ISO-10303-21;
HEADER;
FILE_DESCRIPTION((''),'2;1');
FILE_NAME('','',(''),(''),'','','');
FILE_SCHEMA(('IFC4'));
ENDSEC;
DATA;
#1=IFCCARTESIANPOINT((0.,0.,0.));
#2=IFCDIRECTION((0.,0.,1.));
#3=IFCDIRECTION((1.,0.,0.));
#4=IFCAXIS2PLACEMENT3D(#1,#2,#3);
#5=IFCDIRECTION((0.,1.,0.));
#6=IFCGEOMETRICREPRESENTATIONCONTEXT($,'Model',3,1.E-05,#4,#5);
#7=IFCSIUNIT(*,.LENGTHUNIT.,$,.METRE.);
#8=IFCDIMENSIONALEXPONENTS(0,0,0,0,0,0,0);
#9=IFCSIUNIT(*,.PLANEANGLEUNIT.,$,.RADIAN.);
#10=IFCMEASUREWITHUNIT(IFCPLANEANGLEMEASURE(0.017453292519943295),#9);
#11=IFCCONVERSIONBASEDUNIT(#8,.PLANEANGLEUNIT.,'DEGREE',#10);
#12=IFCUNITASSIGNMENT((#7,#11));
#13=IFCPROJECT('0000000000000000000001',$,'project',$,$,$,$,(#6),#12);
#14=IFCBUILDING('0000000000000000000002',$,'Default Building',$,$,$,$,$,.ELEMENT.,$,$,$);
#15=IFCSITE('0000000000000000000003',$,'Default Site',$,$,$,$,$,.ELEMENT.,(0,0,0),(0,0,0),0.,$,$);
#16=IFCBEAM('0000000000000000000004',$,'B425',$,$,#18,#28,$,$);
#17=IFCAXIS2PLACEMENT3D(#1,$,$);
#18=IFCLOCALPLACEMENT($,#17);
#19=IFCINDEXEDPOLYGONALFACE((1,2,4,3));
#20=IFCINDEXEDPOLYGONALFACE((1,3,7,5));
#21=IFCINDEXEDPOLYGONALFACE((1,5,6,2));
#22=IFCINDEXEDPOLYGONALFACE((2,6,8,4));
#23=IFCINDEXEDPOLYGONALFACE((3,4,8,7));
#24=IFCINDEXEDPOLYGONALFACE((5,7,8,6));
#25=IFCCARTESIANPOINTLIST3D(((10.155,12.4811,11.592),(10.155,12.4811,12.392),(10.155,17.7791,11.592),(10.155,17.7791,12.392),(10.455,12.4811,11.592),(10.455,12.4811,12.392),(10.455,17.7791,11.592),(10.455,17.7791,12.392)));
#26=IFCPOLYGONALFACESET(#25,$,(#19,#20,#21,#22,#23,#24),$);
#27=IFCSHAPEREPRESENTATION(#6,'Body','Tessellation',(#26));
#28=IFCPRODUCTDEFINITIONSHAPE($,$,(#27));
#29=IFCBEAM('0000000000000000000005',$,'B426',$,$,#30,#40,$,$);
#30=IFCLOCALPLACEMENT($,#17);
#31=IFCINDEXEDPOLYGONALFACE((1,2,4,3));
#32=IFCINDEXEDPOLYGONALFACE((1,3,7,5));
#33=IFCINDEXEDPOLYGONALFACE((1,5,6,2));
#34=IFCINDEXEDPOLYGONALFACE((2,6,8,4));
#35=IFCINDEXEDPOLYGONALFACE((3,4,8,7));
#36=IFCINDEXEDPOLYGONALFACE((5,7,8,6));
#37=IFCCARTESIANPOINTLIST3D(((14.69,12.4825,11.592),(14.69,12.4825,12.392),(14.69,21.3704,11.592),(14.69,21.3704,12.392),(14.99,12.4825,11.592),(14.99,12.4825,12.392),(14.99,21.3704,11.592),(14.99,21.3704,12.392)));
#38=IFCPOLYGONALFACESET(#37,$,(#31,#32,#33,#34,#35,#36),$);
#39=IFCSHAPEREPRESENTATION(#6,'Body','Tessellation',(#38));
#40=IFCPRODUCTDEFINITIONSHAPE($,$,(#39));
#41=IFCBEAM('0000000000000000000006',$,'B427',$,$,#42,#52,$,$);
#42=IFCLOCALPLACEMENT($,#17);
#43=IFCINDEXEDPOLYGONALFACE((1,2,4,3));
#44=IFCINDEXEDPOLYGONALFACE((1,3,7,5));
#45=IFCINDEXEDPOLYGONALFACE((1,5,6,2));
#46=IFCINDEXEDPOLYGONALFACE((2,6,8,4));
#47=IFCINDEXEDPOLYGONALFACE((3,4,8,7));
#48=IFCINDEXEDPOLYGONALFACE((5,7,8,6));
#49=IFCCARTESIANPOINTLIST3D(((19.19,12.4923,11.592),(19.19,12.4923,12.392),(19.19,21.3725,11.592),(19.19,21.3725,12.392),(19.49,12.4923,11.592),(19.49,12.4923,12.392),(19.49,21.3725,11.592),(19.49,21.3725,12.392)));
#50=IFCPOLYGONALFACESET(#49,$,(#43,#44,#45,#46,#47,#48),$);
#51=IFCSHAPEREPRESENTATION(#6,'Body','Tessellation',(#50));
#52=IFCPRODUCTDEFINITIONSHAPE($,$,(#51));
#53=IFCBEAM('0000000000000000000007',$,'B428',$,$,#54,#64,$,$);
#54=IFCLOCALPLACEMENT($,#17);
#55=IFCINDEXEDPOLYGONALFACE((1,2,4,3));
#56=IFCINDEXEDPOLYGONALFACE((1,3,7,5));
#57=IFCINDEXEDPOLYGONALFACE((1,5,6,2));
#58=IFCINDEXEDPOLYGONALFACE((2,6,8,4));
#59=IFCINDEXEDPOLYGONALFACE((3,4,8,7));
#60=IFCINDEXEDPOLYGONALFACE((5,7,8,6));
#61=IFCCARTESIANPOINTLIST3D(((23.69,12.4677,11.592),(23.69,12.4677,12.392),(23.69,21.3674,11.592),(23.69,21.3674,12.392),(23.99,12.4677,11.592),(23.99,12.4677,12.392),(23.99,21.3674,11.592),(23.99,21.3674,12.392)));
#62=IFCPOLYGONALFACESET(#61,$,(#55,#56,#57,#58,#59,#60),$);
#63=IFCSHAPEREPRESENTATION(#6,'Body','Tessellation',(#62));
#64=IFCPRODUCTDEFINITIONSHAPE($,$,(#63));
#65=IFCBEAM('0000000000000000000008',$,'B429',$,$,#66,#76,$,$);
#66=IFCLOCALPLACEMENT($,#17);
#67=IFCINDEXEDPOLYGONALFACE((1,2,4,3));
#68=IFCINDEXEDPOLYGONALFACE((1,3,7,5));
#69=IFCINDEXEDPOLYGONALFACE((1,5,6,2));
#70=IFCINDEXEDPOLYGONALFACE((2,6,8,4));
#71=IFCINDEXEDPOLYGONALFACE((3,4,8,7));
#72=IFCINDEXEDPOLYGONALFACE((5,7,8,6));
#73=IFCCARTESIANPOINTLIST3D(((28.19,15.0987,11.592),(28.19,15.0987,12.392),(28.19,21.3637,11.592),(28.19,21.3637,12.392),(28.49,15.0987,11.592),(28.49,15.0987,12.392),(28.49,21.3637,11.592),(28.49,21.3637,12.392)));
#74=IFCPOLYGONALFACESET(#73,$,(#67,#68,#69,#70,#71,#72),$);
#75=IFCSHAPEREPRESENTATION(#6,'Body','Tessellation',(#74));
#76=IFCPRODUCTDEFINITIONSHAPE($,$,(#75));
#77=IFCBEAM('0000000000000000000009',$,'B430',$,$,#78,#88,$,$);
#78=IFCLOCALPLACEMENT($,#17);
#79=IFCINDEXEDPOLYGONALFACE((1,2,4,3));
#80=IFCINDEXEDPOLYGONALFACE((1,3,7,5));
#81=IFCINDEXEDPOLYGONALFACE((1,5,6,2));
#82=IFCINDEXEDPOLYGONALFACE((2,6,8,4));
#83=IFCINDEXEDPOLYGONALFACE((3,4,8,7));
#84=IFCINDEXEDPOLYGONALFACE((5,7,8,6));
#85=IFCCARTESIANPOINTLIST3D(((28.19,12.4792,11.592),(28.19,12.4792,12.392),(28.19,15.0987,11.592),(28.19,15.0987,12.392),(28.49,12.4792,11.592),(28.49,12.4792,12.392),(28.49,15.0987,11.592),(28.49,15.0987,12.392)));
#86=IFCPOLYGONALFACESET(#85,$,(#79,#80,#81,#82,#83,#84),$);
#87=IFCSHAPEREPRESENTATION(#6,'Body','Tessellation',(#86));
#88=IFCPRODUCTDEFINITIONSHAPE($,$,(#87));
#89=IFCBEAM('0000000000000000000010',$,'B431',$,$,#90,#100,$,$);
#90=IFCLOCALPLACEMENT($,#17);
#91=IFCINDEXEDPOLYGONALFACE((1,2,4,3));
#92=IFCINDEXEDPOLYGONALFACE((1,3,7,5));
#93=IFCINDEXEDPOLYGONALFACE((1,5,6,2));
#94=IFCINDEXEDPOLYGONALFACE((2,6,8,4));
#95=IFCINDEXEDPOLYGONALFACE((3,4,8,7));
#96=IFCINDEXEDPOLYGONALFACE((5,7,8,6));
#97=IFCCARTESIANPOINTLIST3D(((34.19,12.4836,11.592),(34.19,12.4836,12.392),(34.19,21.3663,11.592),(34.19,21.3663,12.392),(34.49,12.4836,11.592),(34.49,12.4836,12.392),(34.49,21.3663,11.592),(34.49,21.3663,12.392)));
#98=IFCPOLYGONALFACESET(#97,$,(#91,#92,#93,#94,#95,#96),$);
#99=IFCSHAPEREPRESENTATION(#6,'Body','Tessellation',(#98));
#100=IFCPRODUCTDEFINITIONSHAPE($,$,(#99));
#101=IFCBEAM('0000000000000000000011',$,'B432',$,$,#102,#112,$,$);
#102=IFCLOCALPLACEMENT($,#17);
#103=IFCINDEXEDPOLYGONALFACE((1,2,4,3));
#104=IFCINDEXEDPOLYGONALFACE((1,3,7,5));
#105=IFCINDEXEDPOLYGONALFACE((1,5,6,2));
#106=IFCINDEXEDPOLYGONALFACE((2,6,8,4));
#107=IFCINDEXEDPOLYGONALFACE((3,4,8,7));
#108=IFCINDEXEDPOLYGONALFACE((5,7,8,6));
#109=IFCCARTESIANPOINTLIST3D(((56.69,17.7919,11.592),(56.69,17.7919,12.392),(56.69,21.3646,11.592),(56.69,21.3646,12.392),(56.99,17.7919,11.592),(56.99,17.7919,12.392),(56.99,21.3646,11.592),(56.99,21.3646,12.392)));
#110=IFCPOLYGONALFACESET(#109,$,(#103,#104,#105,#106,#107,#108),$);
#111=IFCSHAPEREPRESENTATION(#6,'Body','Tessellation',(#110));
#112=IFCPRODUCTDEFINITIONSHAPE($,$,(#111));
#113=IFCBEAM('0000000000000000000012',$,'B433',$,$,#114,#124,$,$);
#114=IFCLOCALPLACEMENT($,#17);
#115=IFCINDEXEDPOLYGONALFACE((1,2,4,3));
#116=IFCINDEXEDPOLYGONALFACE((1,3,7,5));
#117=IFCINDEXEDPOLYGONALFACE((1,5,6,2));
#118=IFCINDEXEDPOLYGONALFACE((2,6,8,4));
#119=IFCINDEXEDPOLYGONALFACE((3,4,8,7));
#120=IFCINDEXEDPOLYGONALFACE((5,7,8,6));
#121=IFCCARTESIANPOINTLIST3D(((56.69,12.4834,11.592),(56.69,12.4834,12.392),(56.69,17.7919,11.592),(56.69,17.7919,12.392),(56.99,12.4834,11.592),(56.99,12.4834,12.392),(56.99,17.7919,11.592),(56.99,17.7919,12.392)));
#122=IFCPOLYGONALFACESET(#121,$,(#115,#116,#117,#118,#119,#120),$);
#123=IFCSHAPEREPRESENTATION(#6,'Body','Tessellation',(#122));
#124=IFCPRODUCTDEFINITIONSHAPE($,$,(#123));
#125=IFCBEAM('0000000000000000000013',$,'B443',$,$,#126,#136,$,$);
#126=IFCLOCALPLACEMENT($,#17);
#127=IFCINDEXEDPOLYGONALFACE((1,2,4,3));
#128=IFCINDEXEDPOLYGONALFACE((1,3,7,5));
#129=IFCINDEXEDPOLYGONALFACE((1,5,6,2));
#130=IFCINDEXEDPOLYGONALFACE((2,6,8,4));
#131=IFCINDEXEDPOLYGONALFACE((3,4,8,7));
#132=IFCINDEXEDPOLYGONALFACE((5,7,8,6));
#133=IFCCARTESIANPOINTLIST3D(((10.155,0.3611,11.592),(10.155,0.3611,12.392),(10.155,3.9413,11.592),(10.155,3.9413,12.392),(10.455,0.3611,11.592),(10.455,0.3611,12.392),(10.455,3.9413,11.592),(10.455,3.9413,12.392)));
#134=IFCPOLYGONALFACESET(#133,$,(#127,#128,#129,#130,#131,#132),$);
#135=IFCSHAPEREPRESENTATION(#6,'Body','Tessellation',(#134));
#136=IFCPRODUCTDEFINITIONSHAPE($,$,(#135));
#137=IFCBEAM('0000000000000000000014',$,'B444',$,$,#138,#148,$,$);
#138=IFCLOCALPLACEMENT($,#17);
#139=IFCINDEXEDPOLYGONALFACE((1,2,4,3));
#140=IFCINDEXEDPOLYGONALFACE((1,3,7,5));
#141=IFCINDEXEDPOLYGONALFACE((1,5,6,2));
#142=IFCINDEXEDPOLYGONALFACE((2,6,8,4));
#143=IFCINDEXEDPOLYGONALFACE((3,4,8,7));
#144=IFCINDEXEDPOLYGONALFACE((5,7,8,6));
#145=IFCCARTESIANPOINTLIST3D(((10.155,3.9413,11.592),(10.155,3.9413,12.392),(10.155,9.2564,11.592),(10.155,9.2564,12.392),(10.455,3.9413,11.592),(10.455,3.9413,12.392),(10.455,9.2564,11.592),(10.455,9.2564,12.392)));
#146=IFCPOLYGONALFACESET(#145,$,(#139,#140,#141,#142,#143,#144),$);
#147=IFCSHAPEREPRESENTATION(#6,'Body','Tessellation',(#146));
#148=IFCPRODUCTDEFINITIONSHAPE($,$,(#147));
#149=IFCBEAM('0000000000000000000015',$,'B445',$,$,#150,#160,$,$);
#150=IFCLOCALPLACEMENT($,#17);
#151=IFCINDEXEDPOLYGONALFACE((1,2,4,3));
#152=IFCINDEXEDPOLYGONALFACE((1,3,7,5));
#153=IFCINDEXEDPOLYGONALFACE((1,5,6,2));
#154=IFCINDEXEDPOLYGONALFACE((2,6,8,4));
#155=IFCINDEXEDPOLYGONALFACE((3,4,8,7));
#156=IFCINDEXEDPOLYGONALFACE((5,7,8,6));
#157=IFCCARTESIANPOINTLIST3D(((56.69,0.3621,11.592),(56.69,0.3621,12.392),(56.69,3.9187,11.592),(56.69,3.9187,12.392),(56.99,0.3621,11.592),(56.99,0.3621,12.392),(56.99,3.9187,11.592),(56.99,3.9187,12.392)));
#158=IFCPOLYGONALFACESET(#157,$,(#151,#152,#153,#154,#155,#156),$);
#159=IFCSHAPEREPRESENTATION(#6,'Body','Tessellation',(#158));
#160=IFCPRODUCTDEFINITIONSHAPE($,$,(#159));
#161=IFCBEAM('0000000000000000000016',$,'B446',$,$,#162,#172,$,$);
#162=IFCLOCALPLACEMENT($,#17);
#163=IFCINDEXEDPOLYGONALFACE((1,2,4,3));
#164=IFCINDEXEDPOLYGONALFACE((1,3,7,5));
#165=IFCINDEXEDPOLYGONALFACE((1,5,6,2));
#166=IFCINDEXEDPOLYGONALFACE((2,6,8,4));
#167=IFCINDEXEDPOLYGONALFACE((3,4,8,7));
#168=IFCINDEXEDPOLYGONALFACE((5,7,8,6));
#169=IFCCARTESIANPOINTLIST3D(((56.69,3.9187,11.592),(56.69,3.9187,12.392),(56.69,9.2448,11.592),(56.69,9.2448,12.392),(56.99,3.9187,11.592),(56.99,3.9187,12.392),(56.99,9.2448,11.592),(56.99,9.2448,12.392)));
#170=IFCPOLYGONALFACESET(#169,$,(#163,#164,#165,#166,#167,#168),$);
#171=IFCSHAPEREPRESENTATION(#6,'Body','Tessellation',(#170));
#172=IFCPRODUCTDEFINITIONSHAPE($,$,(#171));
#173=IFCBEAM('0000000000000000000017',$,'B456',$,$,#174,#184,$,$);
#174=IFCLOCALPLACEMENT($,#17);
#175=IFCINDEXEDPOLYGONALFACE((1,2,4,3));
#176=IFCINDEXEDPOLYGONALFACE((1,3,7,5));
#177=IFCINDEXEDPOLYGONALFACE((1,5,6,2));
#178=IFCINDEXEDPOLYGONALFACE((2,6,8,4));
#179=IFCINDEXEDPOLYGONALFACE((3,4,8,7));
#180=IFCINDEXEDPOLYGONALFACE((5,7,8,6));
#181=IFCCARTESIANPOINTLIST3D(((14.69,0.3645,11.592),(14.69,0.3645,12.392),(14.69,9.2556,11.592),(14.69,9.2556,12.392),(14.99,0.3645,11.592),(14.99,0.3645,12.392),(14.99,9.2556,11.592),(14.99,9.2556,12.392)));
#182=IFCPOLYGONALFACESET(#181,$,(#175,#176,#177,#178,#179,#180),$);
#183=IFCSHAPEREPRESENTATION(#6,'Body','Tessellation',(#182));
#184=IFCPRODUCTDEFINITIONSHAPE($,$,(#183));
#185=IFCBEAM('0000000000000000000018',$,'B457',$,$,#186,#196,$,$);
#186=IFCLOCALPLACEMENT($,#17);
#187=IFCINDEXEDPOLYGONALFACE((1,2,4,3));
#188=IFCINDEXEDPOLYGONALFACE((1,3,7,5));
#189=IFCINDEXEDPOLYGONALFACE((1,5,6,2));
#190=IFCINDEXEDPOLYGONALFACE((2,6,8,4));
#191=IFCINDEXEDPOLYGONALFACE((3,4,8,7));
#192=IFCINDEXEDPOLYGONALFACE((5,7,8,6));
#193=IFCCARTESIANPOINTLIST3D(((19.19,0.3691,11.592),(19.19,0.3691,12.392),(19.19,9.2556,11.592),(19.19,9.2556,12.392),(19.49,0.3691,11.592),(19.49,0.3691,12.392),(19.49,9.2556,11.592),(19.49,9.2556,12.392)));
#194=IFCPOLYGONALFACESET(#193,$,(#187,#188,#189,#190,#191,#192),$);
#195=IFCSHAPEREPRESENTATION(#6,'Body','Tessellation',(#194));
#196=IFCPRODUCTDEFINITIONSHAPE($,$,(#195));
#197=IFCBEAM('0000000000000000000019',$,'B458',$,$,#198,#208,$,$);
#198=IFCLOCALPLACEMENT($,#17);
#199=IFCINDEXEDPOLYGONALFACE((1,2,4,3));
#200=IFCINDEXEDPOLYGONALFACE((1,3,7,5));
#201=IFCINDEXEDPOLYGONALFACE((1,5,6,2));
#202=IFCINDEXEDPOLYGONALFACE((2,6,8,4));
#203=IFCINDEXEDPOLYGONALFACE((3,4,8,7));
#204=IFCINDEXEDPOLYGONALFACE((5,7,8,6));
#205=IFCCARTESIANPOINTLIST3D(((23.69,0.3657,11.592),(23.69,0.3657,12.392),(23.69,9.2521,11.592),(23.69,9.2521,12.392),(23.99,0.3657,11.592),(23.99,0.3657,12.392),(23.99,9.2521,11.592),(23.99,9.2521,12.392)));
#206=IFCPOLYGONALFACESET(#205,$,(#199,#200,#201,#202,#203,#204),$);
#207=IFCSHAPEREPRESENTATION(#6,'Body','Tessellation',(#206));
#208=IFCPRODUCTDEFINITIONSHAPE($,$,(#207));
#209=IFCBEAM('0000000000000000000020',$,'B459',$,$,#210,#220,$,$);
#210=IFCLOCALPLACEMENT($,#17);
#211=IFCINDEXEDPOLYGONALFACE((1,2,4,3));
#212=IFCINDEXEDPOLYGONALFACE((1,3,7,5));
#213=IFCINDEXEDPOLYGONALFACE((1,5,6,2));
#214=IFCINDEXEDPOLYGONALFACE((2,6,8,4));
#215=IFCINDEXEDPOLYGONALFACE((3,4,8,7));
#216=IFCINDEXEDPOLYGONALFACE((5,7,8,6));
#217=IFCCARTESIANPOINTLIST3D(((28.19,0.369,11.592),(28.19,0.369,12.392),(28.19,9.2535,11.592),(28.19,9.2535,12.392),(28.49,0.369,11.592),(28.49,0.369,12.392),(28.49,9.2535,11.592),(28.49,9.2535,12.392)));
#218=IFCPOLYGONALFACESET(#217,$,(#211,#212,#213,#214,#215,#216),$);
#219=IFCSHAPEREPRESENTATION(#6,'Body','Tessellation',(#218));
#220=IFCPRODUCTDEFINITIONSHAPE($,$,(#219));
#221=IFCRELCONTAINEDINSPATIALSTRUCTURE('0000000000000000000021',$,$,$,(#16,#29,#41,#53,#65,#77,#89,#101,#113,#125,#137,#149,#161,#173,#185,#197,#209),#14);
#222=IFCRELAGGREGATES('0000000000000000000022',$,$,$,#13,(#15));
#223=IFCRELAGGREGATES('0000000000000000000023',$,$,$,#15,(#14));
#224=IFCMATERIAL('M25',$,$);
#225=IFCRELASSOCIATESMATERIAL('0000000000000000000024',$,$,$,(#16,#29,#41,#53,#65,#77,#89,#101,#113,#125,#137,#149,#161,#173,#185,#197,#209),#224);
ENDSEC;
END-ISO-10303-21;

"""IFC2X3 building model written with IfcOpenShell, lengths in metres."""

from ifc_helpers import new_model, entity, si_unit, converted_unit, direction, frame, frame_2d, origin_with_axes, place, context, project, spatial, rectangle, extrude, material, element, save


model = new_model("IFC2X3")

# Units and contexts
model_context = context("Model", 3, precision=1e-05, world=origin_with_axes(), true_north=direction((0.0, 1.0, 0.0)))
ifc_project = project(units=[si_unit("LENGTHUNIT", "METRE"), converted_unit("PLANEANGLEUNIT", "DEGREE", entity("IfcPlaneAngleMeasure", 0.017453292519943295), si_unit("PLANEANGLEUNIT", "RADIAN"), dimensions=[0, 0, 0, 0, 0, 0, 0])], contexts=[model_context])

# Site, building
site = spatial("IfcSite", under=ifc_project, Name="Default Site", CompositionType="ELEMENT", RefLatitude=(0, 0, 0), RefLongitude=(0, 0, 0), RefElevation=0.0)
building = spatial("IfcBuilding", under=site, Name="Default Building", CompositionType="ELEMENT")

# Beams
ifc_material = material(Name="M25")
placement = place(None, origin_with_axes())
element("IfcBeam", 1, at=placement, inside=building, material=ifc_material, Name="B425", context=model_context, shape_type="SweptSolid", body=[
    extrude(rectangle(XDim=0.3, YDim=0.8, at=frame_2d((0.0, 0.0), x_axis=(0.0, 1.0, 0.0))), frame((10.305, 17.7791, 11.992), z_axis=(0.0, -1.0, 0.0), x_axis=(0.0, 0.0, -1.0)), (0.0, 0.0, 1.0), 5.298),
])
element("IfcBeam", 2, at=placement, inside=building, material=ifc_material, Name="B426", context=model_context, shape_type="SweptSolid", body=[
    extrude(rectangle(XDim=0.3, YDim=0.8, at=frame_2d((0.0, 0.0), x_axis=(0.0, 1.0, 0.0))), frame((14.84, 21.3704, 11.992), z_axis=(0.0, -1.0, 0.0), x_axis=(0.0, 0.0, -1.0)), (0.0, 0.0, 1.0), 8.8879),
])
element("IfcBeam", 3, at=placement, inside=building, material=ifc_material, Name="B427", context=model_context, shape_type="SweptSolid", body=[
    extrude(rectangle(XDim=0.3, YDim=0.8, at=frame_2d((0.0, 0.0), x_axis=(0.0, 1.0, 0.0))), frame((19.34, 21.3725, 11.992), z_axis=(0.0, -1.0, 0.0), x_axis=(0.0, 0.0, -1.0)), (0.0, 0.0, 1.0), 8.8802),
])
element("IfcBeam", 4, at=placement, inside=building, material=ifc_material, Name="B428", context=model_context, shape_type="SweptSolid", body=[
    extrude(rectangle(XDim=0.3, YDim=0.8, at=frame_2d((0.0, 0.0), x_axis=(0.0, 1.0, 0.0))), frame((23.84, 21.3674, 11.992), z_axis=(0.0, -1.0, 0.0), x_axis=(0.0, 0.0, -1.0)), (0.0, 0.0, 1.0), 8.8997),
])
element("IfcBeam", 5, at=placement, inside=building, material=ifc_material, Name="B429", context=model_context, shape_type="SweptSolid", body=[
    extrude(rectangle(XDim=0.3, YDim=0.8, at=frame_2d((0.0, 0.0), x_axis=(0.0, 1.0, 0.0))), frame((28.34, 21.3637, 11.992), z_axis=(0.0, -1.0, 0.0), x_axis=(0.0, 0.0, -1.0)), (0.0, 0.0, 1.0), 6.265),
])
element("IfcBeam", 6, at=placement, inside=building, material=ifc_material, Name="B430", context=model_context, shape_type="SweptSolid", body=[
    extrude(rectangle(XDim=0.3, YDim=0.8, at=frame_2d((0.0, 0.0), x_axis=(0.0, 1.0, 0.0))), frame((28.34, 15.0987, 11.992), z_axis=(0.0, -1.0, 0.0), x_axis=(0.0, 0.0, -1.0)), (0.0, 0.0, 1.0), 2.6195),
])
element("IfcBeam", 7, at=placement, inside=building, material=ifc_material, Name="B431", context=model_context, shape_type="SweptSolid", body=[
    extrude(rectangle(XDim=0.3, YDim=0.8, at=frame_2d((0.0, 0.0), x_axis=(0.0, 1.0, 0.0))), frame((34.34, 12.4836, 11.992), z_axis=(0.0, 1.0, 0.0), x_axis=(0.0, 0.0, -1.0)), (0.0, 0.0, 1.0), 8.8827),
])
element("IfcBeam", 8, at=placement, inside=building, material=ifc_material, Name="B432", context=model_context, shape_type="SweptSolid", body=[
    extrude(rectangle(XDim=0.3, YDim=0.8, at=frame_2d((0.0, 0.0), x_axis=(0.0, 1.0, 0.0))), frame((56.84, 17.7919, 11.992), z_axis=(0.0, 1.0, 0.0), x_axis=(0.0, 0.0, -1.0)), (0.0, 0.0, 1.0), 3.5727),
])
element("IfcBeam", 9, at=placement, inside=building, material=ifc_material, Name="B433", context=model_context, shape_type="SweptSolid", body=[
    extrude(rectangle(XDim=0.3, YDim=0.8, at=frame_2d((0.0, 0.0), x_axis=(0.0, 1.0, 0.0))), frame((56.84, 12.4834, 11.992), z_axis=(0.0, 1.0, 0.0), x_axis=(0.0, 0.0, -1.0)), (0.0, 0.0, 1.0), 5.3085),
])
element("IfcBeam", 10, at=placement, inside=building, material=ifc_material, Name="B443", context=model_context, shape_type="SweptSolid", body=[
    extrude(rectangle(XDim=0.3, YDim=0.8, at=frame_2d((0.0, 0.0), x_axis=(0.0, 1.0, 0.0))), frame((10.305, 3.9413, 11.992), z_axis=(0.0, -1.0, 0.0), x_axis=(0.0, 0.0, -1.0)), (0.0, 0.0, 1.0), 3.5802),
])
element("IfcBeam", 11, at=placement, inside=building, material=ifc_material, Name="B444", context=model_context, shape_type="SweptSolid", body=[
    extrude(rectangle(XDim=0.3, YDim=0.8, at=frame_2d((0.0, 0.0), x_axis=(0.0, 1.0, 0.0))), frame((10.305, 3.9413, 11.992), z_axis=(0.0, 1.0, 0.0), x_axis=(0.0, 0.0, -1.0)), (0.0, 0.0, 1.0), 5.3151),
])
element("IfcBeam", 12, at=placement, inside=building, material=ifc_material, Name="B445", context=model_context, shape_type="SweptSolid", body=[
    extrude(rectangle(XDim=0.3, YDim=0.8, at=frame_2d((0.0, 0.0), x_axis=(0.0, 1.0, 0.0))), frame((56.84, 0.3621, 11.992), z_axis=(0.0, 1.0, 0.0), x_axis=(0.0, 0.0, -1.0)), (0.0, 0.0, 1.0), 3.5566),
])
element("IfcBeam", 13, at=placement, inside=building, material=ifc_material, Name="B446", context=model_context, shape_type="SweptSolid", body=[
    extrude(rectangle(XDim=0.3, YDim=0.8, at=frame_2d((0.0, 0.0), x_axis=(0.0, 1.0, 0.0))), frame((56.84, 3.9187, 11.992), z_axis=(0.0, 1.0, 0.0), x_axis=(0.0, 0.0, -1.0)), (0.0, 0.0, 1.0), 5.3261),
])
element("IfcBeam", 14, at=placement, inside=building, material=ifc_material, Name="B456", context=model_context, shape_type="SweptSolid", body=[
    extrude(rectangle(XDim=0.3, YDim=0.8, at=frame_2d((0.0, 0.0), x_axis=(0.0, 1.0, 0.0))), frame((14.84, 0.3645, 11.992), z_axis=(0.0, 1.0, 0.0), x_axis=(0.0, 0.0, -1.0)), (0.0, 0.0, 1.0), 8.891),
])
element("IfcBeam", 15, at=placement, inside=building, material=ifc_material, Name="B457", context=model_context, shape_type="SweptSolid", body=[
    extrude(rectangle(XDim=0.3, YDim=0.8, at=frame_2d((0.0, 0.0), x_axis=(0.0, 1.0, 0.0))), frame((19.34, 0.3691, 11.992), z_axis=(0.0, 1.0, 0.0), x_axis=(0.0, 0.0, -1.0)), (0.0, 0.0, 1.0), 8.8865),
])
element("IfcBeam", 16, at=placement, inside=building, material=ifc_material, Name="B458", context=model_context, shape_type="SweptSolid", body=[
    extrude(rectangle(XDim=0.3, YDim=0.8, at=frame_2d((0.0, 0.0), x_axis=(0.0, 1.0, 0.0))), frame((23.84, 0.3657, 11.992), z_axis=(0.0, 1.0, 0.0), x_axis=(0.0, 0.0, -1.0)), (0.0, 0.0, 1.0), 8.8864),
])
element("IfcBeam", 17, at=placement, inside=building, material=ifc_material, Name="B459", context=model_context, shape_type="SweptSolid", body=[
    extrude(rectangle(XDim=0.3, YDim=0.8, at=frame_2d((0.0, 0.0), x_axis=(0.0, 1.0, 0.0))), frame((28.34, 0.369, 11.992), z_axis=(0.0, 1.0, 0.0), x_axis=(0.0, 0.0, -1.0)), (0.0, 0.0, 1.0), 8.8845),
])

save(model, "model.ifc")
